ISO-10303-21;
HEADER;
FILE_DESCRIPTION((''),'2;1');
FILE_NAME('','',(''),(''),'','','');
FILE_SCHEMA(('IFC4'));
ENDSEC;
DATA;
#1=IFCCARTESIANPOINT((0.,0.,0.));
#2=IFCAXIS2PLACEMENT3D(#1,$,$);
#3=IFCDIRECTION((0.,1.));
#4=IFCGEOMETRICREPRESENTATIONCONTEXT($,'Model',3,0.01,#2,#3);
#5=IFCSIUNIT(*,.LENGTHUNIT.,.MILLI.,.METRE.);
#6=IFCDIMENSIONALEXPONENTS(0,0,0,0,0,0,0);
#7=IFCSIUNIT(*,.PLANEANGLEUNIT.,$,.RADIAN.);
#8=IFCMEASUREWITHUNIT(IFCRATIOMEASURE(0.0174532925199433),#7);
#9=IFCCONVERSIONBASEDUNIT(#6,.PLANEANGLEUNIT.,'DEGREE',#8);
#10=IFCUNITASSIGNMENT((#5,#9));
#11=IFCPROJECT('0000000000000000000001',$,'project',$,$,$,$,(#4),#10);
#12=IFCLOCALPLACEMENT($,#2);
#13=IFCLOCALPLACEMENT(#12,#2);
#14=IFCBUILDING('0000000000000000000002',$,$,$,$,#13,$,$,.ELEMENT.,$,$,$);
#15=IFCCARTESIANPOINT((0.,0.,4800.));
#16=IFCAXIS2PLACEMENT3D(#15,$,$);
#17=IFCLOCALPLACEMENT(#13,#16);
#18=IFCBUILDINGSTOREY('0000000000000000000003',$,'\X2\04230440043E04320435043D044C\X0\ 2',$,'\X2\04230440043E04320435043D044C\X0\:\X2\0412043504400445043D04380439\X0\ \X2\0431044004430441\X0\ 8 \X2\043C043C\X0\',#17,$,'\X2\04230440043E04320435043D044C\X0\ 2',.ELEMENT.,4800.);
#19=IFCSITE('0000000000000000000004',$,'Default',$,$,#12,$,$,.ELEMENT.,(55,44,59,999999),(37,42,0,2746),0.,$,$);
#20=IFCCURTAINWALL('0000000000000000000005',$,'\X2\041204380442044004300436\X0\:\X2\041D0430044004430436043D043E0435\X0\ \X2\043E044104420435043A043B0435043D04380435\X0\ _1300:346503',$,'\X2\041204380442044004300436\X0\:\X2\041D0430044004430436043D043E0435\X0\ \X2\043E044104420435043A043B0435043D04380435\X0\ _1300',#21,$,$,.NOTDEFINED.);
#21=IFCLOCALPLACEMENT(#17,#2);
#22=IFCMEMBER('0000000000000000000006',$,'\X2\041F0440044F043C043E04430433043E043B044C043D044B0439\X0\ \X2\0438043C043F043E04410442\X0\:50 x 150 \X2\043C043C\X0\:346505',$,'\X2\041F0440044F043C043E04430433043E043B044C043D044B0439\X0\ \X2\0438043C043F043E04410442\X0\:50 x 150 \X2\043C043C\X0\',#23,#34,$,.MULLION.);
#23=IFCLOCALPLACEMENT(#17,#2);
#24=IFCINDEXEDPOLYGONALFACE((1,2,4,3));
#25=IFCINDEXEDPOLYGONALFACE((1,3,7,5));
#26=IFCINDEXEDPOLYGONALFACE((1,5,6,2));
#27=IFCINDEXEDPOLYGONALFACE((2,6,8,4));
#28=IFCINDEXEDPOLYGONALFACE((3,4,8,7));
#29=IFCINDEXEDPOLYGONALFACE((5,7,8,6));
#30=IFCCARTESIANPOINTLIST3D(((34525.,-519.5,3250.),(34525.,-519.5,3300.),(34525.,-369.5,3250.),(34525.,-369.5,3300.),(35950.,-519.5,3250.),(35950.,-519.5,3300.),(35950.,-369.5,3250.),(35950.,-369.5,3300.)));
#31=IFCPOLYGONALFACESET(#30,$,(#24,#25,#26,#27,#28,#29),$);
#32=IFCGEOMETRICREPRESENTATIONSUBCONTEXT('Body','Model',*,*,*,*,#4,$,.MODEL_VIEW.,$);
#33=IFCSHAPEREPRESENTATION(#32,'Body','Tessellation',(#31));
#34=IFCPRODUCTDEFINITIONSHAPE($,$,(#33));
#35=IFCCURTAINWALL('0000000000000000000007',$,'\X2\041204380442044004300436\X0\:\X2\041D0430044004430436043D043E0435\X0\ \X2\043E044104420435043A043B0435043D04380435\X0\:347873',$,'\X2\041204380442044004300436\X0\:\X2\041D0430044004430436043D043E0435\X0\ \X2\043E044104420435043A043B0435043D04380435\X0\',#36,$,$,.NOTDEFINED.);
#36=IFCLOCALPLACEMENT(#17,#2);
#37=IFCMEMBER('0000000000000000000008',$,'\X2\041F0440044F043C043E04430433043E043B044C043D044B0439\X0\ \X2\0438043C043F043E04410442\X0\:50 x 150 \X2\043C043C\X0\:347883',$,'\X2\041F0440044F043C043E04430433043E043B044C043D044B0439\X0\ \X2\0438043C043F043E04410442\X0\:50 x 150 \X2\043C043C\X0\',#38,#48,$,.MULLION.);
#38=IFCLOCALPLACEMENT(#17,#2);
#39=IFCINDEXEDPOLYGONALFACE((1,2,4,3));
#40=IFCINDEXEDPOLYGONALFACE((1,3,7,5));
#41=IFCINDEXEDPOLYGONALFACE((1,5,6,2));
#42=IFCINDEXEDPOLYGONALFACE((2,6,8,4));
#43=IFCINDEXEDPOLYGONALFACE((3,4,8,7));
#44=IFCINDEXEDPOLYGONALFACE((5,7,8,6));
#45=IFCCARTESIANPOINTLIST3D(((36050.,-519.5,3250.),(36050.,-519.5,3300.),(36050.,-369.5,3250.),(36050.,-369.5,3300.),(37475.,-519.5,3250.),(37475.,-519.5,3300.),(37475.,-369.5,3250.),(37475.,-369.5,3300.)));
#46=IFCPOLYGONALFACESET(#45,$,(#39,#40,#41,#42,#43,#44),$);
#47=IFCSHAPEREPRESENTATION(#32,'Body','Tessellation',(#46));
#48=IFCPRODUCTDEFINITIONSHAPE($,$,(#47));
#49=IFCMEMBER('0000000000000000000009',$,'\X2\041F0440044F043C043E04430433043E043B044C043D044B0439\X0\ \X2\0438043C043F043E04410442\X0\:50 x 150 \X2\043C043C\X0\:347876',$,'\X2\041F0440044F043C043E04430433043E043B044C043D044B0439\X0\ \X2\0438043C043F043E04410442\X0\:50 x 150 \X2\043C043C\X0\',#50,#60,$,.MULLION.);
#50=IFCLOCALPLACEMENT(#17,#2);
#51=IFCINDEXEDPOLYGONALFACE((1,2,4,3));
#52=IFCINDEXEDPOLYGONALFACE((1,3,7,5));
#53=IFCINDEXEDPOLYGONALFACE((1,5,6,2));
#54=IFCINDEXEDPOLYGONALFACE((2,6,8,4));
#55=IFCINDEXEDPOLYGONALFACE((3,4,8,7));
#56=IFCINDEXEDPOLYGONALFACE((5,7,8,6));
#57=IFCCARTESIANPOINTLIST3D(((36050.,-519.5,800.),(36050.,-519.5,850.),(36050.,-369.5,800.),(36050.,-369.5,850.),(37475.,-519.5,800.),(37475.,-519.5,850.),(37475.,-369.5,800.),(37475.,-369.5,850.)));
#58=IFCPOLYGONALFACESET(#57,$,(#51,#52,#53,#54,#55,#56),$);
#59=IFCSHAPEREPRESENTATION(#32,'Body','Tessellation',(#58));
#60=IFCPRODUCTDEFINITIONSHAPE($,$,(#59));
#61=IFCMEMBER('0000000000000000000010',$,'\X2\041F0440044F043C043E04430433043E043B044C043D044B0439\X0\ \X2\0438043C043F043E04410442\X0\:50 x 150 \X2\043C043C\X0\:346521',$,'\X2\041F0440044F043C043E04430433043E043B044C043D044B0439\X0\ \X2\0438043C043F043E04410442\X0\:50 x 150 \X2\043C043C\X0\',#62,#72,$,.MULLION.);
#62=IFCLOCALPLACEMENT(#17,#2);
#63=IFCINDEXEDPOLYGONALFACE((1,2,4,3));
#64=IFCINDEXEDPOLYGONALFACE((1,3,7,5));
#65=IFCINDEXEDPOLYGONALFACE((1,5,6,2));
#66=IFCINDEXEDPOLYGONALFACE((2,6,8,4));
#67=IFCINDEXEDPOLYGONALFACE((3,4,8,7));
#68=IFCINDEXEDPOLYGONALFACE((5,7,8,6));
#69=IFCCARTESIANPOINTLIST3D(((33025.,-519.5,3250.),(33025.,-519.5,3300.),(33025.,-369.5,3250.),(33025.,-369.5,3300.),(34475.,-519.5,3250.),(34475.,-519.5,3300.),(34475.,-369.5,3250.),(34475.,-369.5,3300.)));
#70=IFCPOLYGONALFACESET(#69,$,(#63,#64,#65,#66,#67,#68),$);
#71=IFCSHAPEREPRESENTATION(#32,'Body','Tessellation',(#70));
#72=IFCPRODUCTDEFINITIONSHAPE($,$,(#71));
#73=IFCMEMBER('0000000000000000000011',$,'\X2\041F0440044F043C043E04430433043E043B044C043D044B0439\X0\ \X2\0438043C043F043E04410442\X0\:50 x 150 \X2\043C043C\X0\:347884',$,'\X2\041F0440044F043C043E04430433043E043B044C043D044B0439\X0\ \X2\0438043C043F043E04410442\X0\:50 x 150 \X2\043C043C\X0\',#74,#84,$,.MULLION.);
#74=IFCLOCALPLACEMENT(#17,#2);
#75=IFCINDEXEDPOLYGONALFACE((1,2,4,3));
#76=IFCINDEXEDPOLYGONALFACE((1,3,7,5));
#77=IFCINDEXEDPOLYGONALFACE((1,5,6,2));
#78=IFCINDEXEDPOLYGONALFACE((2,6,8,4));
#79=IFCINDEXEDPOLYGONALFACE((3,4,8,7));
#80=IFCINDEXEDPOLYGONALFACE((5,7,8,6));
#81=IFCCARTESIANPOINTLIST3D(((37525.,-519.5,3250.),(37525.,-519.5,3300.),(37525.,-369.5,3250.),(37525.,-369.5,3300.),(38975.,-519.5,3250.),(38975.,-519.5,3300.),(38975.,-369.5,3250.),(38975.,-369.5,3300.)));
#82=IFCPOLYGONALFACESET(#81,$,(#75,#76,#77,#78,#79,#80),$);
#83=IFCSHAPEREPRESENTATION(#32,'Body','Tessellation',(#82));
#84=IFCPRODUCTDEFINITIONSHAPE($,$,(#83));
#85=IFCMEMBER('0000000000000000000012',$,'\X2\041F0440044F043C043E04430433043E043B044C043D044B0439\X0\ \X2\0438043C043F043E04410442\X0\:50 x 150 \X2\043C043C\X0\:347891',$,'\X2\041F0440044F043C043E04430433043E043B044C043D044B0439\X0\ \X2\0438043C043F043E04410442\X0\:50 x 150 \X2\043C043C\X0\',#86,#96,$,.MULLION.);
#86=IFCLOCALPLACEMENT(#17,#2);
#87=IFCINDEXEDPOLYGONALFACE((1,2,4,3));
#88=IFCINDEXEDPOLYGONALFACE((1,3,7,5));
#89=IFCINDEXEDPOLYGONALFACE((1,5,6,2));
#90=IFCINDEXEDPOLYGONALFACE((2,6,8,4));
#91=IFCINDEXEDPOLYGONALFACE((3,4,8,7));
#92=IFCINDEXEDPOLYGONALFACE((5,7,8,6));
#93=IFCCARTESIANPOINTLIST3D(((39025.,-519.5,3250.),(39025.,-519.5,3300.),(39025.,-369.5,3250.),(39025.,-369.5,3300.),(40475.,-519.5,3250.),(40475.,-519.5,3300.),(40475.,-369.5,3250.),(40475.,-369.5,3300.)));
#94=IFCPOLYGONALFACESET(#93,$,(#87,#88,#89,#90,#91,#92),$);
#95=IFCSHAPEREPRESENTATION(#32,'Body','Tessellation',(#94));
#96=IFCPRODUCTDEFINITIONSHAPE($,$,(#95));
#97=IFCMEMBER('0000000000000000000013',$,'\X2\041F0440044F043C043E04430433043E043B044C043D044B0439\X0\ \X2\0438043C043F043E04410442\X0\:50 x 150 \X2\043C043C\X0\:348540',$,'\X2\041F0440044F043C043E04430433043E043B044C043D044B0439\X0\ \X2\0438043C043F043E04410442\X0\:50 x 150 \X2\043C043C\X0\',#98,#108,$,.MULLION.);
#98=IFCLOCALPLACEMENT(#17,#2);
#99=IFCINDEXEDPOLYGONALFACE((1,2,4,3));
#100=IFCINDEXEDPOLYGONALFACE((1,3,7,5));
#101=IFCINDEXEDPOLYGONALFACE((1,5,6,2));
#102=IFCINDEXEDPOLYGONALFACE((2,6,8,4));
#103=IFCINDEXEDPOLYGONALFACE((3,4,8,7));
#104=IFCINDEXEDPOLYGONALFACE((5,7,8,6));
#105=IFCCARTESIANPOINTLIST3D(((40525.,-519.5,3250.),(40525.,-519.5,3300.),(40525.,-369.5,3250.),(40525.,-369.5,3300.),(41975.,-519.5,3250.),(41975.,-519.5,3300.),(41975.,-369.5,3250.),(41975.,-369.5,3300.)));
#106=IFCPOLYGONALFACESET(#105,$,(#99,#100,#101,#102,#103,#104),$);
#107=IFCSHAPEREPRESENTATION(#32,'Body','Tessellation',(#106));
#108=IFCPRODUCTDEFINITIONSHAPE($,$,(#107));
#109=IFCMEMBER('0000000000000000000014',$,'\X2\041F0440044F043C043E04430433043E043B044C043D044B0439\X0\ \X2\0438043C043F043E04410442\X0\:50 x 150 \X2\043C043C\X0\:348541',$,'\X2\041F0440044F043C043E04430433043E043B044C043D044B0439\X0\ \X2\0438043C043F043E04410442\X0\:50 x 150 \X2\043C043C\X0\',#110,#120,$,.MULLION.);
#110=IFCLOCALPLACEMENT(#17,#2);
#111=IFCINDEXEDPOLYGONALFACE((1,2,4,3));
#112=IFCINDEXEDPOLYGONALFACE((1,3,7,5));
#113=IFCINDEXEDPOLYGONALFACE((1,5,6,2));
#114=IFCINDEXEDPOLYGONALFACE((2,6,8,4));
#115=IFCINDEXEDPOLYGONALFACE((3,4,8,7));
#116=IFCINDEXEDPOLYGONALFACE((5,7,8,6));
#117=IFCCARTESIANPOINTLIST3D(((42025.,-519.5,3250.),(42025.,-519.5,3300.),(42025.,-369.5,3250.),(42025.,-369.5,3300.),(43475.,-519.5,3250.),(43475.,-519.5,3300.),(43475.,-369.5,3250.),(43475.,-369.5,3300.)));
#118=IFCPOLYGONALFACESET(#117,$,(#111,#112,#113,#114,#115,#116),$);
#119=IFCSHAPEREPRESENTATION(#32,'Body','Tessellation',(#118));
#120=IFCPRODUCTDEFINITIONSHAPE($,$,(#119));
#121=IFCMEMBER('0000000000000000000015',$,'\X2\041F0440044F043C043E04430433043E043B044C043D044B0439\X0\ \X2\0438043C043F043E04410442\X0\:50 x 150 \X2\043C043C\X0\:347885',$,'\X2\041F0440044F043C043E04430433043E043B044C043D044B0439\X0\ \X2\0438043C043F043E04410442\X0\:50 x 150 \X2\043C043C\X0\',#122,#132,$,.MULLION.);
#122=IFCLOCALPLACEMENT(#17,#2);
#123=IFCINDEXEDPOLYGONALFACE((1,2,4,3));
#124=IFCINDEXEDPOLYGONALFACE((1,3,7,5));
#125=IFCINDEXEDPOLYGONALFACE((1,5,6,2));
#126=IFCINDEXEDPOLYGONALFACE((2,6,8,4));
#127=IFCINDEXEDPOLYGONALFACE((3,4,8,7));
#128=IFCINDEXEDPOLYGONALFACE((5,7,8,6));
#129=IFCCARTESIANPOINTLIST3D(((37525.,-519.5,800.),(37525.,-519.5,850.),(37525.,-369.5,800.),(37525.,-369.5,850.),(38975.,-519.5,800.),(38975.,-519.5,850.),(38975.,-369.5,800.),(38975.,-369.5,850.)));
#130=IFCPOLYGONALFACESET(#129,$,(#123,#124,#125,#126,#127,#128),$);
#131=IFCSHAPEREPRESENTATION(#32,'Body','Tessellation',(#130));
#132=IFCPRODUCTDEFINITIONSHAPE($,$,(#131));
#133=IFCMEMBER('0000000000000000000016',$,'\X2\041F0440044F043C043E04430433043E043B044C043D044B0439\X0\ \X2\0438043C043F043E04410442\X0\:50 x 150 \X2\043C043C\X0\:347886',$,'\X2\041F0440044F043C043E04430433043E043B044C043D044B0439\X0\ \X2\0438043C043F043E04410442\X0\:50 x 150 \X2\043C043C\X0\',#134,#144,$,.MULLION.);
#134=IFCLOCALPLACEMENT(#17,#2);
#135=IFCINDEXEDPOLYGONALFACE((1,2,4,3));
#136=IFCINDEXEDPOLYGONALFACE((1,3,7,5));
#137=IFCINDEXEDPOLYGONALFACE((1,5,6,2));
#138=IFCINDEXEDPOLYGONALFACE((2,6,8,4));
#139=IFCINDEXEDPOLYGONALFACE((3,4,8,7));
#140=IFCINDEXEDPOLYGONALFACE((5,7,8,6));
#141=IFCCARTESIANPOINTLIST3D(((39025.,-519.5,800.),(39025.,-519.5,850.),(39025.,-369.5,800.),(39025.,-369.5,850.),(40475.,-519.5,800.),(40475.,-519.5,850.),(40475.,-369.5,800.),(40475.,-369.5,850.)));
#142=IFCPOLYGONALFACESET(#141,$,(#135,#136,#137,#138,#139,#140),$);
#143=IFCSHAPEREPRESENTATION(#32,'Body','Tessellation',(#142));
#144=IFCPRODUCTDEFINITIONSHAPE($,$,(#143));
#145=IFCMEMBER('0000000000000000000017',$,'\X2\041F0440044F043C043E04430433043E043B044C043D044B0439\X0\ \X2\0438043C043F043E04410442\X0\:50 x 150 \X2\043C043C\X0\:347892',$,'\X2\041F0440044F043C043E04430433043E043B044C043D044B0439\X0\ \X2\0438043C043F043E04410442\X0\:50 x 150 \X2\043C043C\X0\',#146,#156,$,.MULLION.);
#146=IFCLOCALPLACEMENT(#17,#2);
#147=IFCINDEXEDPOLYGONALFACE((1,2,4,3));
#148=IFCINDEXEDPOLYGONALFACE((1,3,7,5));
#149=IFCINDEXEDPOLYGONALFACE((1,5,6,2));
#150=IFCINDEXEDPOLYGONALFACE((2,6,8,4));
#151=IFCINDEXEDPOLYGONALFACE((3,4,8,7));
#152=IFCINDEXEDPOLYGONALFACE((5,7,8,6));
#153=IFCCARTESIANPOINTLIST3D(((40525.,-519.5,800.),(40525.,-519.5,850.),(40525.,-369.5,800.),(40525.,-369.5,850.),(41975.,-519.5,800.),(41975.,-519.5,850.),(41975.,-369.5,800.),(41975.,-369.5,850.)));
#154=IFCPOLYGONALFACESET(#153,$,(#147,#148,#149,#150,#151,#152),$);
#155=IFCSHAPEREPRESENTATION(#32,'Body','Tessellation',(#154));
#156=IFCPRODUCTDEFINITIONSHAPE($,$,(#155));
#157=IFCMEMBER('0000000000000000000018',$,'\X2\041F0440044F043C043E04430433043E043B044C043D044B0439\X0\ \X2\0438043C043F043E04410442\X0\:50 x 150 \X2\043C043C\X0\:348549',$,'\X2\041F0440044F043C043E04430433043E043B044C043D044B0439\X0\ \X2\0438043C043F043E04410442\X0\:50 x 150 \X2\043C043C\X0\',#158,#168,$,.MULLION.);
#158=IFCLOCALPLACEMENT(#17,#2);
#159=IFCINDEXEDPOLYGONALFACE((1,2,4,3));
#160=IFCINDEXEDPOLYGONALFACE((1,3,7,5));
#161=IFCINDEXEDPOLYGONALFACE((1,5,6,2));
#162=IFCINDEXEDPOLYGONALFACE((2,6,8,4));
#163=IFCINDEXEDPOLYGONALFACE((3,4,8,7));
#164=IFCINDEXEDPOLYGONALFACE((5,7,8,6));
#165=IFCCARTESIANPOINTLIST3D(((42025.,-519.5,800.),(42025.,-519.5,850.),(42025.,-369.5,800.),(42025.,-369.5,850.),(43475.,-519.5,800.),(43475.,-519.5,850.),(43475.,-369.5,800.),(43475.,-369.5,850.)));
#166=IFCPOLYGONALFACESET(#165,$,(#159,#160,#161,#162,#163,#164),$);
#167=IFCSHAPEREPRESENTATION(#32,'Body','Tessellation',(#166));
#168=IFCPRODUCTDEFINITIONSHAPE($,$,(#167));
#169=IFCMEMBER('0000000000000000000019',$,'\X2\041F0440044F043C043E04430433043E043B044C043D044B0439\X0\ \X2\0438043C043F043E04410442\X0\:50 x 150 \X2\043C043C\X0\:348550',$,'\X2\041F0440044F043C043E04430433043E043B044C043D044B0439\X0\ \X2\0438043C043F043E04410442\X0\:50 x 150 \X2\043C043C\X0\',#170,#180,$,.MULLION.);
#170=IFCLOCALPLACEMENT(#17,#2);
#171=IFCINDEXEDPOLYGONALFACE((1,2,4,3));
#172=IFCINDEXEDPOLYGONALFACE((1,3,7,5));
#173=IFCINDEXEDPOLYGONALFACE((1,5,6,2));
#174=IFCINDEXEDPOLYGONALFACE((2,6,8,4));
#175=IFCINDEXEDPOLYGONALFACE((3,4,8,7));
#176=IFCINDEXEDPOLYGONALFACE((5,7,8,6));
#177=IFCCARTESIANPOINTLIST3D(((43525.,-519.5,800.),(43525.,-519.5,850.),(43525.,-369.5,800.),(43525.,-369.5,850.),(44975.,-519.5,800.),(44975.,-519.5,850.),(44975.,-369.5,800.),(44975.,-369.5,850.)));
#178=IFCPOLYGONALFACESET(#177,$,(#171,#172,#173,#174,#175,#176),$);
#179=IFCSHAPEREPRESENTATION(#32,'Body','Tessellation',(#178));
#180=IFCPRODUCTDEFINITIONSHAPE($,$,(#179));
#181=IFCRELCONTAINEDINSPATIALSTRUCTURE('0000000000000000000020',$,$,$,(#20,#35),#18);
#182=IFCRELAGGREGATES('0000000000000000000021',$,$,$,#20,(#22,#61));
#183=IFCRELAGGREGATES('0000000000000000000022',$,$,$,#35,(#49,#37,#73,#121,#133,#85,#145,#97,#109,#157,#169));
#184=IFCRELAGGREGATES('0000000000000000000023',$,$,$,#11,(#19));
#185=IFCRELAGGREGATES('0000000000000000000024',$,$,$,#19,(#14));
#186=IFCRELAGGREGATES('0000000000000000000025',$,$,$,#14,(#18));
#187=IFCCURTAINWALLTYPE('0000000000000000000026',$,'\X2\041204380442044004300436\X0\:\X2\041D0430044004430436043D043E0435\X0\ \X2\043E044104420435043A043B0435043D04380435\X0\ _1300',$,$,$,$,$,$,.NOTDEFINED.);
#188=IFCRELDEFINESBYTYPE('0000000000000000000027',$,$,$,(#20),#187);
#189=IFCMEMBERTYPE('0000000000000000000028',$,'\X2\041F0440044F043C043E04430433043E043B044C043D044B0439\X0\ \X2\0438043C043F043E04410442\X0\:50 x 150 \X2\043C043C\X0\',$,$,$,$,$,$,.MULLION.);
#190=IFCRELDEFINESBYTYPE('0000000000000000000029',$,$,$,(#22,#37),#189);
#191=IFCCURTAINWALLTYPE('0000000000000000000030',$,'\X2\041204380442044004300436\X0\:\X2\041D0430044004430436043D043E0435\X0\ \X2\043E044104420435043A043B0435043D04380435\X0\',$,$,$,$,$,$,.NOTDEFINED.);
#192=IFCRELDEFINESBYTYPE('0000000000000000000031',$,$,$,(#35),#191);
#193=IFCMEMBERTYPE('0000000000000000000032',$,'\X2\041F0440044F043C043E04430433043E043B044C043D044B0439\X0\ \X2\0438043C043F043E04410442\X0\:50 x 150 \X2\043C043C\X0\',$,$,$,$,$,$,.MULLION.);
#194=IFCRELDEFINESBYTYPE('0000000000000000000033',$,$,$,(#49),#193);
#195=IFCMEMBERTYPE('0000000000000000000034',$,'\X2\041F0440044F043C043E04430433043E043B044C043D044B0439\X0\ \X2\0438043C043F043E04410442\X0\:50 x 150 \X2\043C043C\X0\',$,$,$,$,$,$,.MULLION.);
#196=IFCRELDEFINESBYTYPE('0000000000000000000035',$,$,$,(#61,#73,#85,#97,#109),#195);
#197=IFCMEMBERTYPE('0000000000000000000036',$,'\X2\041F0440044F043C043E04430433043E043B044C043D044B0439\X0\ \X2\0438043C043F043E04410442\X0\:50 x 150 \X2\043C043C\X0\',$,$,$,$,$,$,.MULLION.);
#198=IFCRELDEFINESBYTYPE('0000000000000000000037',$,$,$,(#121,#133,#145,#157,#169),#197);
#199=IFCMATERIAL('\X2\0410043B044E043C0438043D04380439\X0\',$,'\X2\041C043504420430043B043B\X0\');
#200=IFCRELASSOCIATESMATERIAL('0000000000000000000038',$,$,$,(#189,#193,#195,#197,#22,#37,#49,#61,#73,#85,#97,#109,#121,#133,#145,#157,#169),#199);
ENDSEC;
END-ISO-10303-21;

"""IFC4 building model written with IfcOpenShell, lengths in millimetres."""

from ifc_helpers import new_model, entity, si_unit, converted_unit, direction, frame, origin, origin_2d_with_axis, place, context, subcontext, project, spatial, rectangle, extrude, source, transform, mapped, material, material_profile, profile_set, profile_usage, type_object, type_shapes, element, aggregate, save


model = new_model("IFC4")

# Units and contexts
model_context = context("Model", 3, precision=0.01, world=origin(), true_north=direction((0.0, 1.0)))
body_context = subcontext(model_context, "Body", "Model", "MODEL_VIEW")
ifc_project = project(units=[si_unit("LENGTHUNIT", "METRE", prefix="MILLI"), converted_unit("PLANEANGLEUNIT", "DEGREE", entity("IfcRatioMeasure", 0.0174532925199433), si_unit("PLANEANGLEUNIT", "RADIAN"), dimensions=[0, 0, 0, 0, 0, 0, 0])], contexts=[model_context])

# Site, building, storey
site_placement = place(None, origin())
site = spatial("IfcSite", under=ifc_project, at=site_placement, Name="Default", CompositionType="ELEMENT", RefLatitude=(55, 44, 59, 999999), RefLongitude=(37, 42, 0, 2746), RefElevation=0.0)
building_placement = place(site_placement, origin())
building = spatial("IfcBuilding", under=site, at=building_placement, CompositionType="ELEMENT")
storey_placement = place(building_placement, frame((0.0, 0.0, 4800.0)))
storey = spatial("IfcBuildingStorey", under=building, at=storey_placement, Name="Уровень 2", ObjectType="Уровень:Верхний брус 8 мм", LongName="Уровень 2", CompositionType="ELEMENT", Elevation=4800.0)

# Curtain wall, member
curtain_wall_type_1 = type_object("IfcCurtainWallType", Name="Витраж:Наружное остекление _1300", PredefinedType="NOTDEFINED")
curtain_wall_1_placement = place(storey_placement, frame((0.0, 0.0, -4800.0)))
curtain_wall_1 = element("IfcCurtainWall", 1, at=curtain_wall_1_placement, inside=storey, type_object=curtain_wall_type_1, Name="Витраж:Наружное остекление _1300:346503", ObjectType="Витраж:Наружное остекление _1300", PredefinedType="NOTDEFINED")
ifc_material = material(Name="Алюминий", Category="Металл")
ifc_material_profile = material_profile(ifc_material, rectangle(XDim=150.0, YDim=50.0, at=origin_2d_with_axis()), Name="50 x 150 мм")
ifc_profile_set = profile_set([ifc_material_profile], Name="50 x 150 мм")
ifc_profile_usage_1 = profile_usage(ifc_profile_set)
member_type_1 = type_object("IfcMemberType", Name="Прямоугольный импост:50 x 150 мм", PredefinedType="MULLION", material=ifc_profile_set)
shared_shape_1 = source(origin(), body_context, "Body", "SweptSolid", [
    extrude(rectangle(XDim=150.0, YDim=50.0, at=origin_2d_with_axis()), frame((-25.0, 0.0, -1425.0), z_axis=(0.0, 0.0, 1.0), x_axis=(0.0, -1.0, 0.0)), (0.0, 0.0, 1.0), 1425.0),
])
type_shapes(member_type_1, [shared_shape_1])
member_1_placement = place(storey_placement, frame((35950.0, -444.5, 3300.0), z_axis=(1.0, 0.0, 0.0), x_axis=(0.0, 0.0, 1.0)))
member_1 = element("IfcMember", 2, at=member_1_placement, type_object=member_type_1, material=ifc_profile_usage_1, Name="Прямоугольный импост:50 x 150 мм:346505", ObjectType="Прямоугольный импост:50 x 150 мм", PredefinedType="MULLION", context=body_context, shape_type="MappedRepresentation", body=[
    mapped(shared_shape_1, transform((0.0, 0.0, 0.0), scale=1.0)),
])

# Curtain wall, members
curtain_wall_type_2 = type_object("IfcCurtainWallType", Name="Витраж:Наружное остекление", PredefinedType="NOTDEFINED")
curtain_wall_2_placement = place(storey_placement, frame((0.0, 0.0, -4800.0)))
curtain_wall_2 = element("IfcCurtainWall", 3, at=curtain_wall_2_placement, inside=storey, type_object=curtain_wall_type_2, Name="Витраж:Наружное остекление:347873", ObjectType="Витраж:Наружное остекление", PredefinedType="NOTDEFINED")
ifc_profile_usage_2 = profile_usage(ifc_profile_set)
member_2_placement = place(storey_placement, frame((37475.0, -444.5, 3300.0), z_axis=(1.0, 0.0, 0.0), x_axis=(0.0, 0.0, 1.0)))
member_2 = element("IfcMember", 4, at=member_2_placement, type_object=member_type_1, material=ifc_profile_usage_2, Name="Прямоугольный импост:50 x 150 мм:347883", ObjectType="Прямоугольный импост:50 x 150 мм", PredefinedType="MULLION", context=body_context, shape_type="MappedRepresentation", body=[
    mapped(shared_shape_1, transform((0.0, 0.0, 0.0), scale=1.0)),
])
ifc_profile_usage_3 = profile_usage(ifc_profile_set)
member_type_2 = type_object("IfcMemberType", Name="Прямоугольный импост:50 x 150 мм", PredefinedType="MULLION", material=ifc_profile_set)
shared_shape_2 = source(origin(), body_context, "Body", "SweptSolid", [
    extrude(rectangle(XDim=150.0, YDim=50.0, at=origin_2d_with_axis()), frame((-25.0, 0.0, -1425.0), z_axis=(0.0, 0.0, 1.0), x_axis=(0.0, -1.0, 0.0)), (0.0, 0.0, 1.0), 1425.0),
])
type_shapes(member_type_2, [shared_shape_2])
member_3_placement = place(storey_placement, frame((36050.0, -444.5, 800.0), z_axis=(-1.0, 0.0, 0.0), x_axis=(0.0, 0.0, -1.0)))
member_3 = element("IfcMember", 5, at=member_3_placement, type_object=member_type_2, material=ifc_profile_usage_3, Name="Прямоугольный импост:50 x 150 мм:347876", ObjectType="Прямоугольный импост:50 x 150 мм", PredefinedType="MULLION", context=body_context, shape_type="MappedRepresentation", body=[
    mapped(shared_shape_2, transform((0.0, 0.0, 0.0), scale=1.0)),
])

# Members
ifc_profile_usage_4 = profile_usage(ifc_profile_set)
member_type_3 = type_object("IfcMemberType", Name="Прямоугольный импост:50 x 150 мм", PredefinedType="MULLION", material=ifc_profile_set)
shared_shape_3 = source(origin(), body_context, "Body", "SweptSolid", [
    extrude(rectangle(XDim=150.0, YDim=50.0, at=origin_2d_with_axis()), frame((-25.0, 0.0, -1450.0), z_axis=(0.0, 0.0, 1.0), x_axis=(0.0, -1.0, 0.0)), (0.0, 0.0, 1.0), 1450.0),
])
type_shapes(member_type_3, [shared_shape_3])
member_4_placement = place(storey_placement, frame((34475.0, -444.5, 3300.0), z_axis=(1.0, 0.0, 0.0), x_axis=(0.0, 0.0, 1.0)))
member_4 = element("IfcMember", 6, at=member_4_placement, type_object=member_type_3, material=ifc_profile_usage_4, Name="Прямоугольный импост:50 x 150 мм:346521", ObjectType="Прямоугольный импост:50 x 150 мм", PredefinedType="MULLION", context=body_context, shape_type="MappedRepresentation", body=[
    mapped(shared_shape_3, transform((0.0, 0.0, 0.0), scale=1.0)),
])
ifc_profile_usage_5 = profile_usage(ifc_profile_set)
member_5_placement = place(storey_placement, frame((38975.0, -444.5, 3300.0), z_axis=(1.0, 0.0, 0.0), x_axis=(0.0, 0.0, 1.0)))
member_5 = element("IfcMember", 7, at=member_5_placement, type_object=member_type_3, material=ifc_profile_usage_5, Name="Прямоугольный импост:50 x 150 мм:347884", ObjectType="Прямоугольный импост:50 x 150 мм", PredefinedType="MULLION", context=body_context, shape_type="MappedRepresentation", body=[
    mapped(shared_shape_3, transform((0.0, 0.0, 0.0), scale=1.0)),
])
ifc_profile_usage_6 = profile_usage(ifc_profile_set)
member_6_placement = place(storey_placement, frame((40475.0, -444.5, 3300.0), z_axis=(1.0, 0.0, 0.0), x_axis=(0.0, 0.0, 1.0)))
member_6 = element("IfcMember", 8, at=member_6_placement, type_object=member_type_3, material=ifc_profile_usage_6, Name="Прямоугольный импост:50 x 150 мм:347891", ObjectType="Прямоугольный импост:50 x 150 мм", PredefinedType="MULLION", context=body_context, shape_type="MappedRepresentation", body=[
    mapped(shared_shape_3, transform((0.0, 0.0, 0.0), scale=1.0)),
])
ifc_profile_usage_7 = profile_usage(ifc_profile_set)
member_7_placement = place(storey_placement, frame((41975.0, -444.5, 3300.0), z_axis=(1.0, 0.0, 0.0), x_axis=(0.0, 0.0, 1.0)))
member_7 = element("IfcMember", 9, at=member_7_placement, type_object=member_type_3, material=ifc_profile_usage_7, Name="Прямоугольный импост:50 x 150 мм:348540", ObjectType="Прямоугольный импост:50 x 150 мм", PredefinedType="MULLION", context=body_context, shape_type="MappedRepresentation", body=[
    mapped(shared_shape_3, transform((0.0, 0.0, 0.0), scale=1.0)),
])
ifc_profile_usage_8 = profile_usage(ifc_profile_set)
member_8_placement = place(storey_placement, frame((43475.0, -444.5, 3300.0), z_axis=(1.0, 0.0, 0.0), x_axis=(0.0, 0.0, 1.0)))
member_8 = element("IfcMember", 10, at=member_8_placement, type_object=member_type_3, material=ifc_profile_usage_8, Name="Прямоугольный импост:50 x 150 мм:348541", ObjectType="Прямоугольный импост:50 x 150 мм", PredefinedType="MULLION", context=body_context, shape_type="MappedRepresentation", body=[
    mapped(shared_shape_3, transform((0.0, 0.0, 0.0), scale=1.0)),
])
ifc_profile_usage_9 = profile_usage(ifc_profile_set)
member_type_4 = type_object("IfcMemberType", Name="Прямоугольный импост:50 x 150 мм", PredefinedType="MULLION", material=ifc_profile_set)
shared_shape_4 = source(origin(), body_context, "Body", "SweptSolid", [
    extrude(rectangle(XDim=150.0, YDim=50.0, at=origin_2d_with_axis()), frame((-25.0, 0.0, -1450.0), z_axis=(0.0, 0.0, 1.0), x_axis=(0.0, -1.0, 0.0)), (0.0, 0.0, 1.0), 1450.0),
])
type_shapes(member_type_4, [shared_shape_4])
member_9_placement = place(storey_placement, frame((37525.0, -444.5, 800.0), z_axis=(-1.0, 0.0, 0.0), x_axis=(0.0, 0.0, -1.0)))
member_9 = element("IfcMember", 11, at=member_9_placement, type_object=member_type_4, material=ifc_profile_usage_9, Name="Прямоугольный импост:50 x 150 мм:347885", ObjectType="Прямоугольный импост:50 x 150 мм", PredefinedType="MULLION", context=body_context, shape_type="MappedRepresentation", body=[
    mapped(shared_shape_4, transform((0.0, 0.0, 0.0), scale=1.0)),
])
ifc_profile_usage_10 = profile_usage(ifc_profile_set)
member_10_placement = place(storey_placement, frame((39025.0, -444.5, 800.0), z_axis=(-1.0, 0.0, 0.0), x_axis=(0.0, 0.0, -1.0)))
member_10 = element("IfcMember", 12, at=member_10_placement, type_object=member_type_4, material=ifc_profile_usage_10, Name="Прямоугольный импост:50 x 150 мм:347886", ObjectType="Прямоугольный импост:50 x 150 мм", PredefinedType="MULLION", context=body_context, shape_type="MappedRepresentation", body=[
    mapped(shared_shape_4, transform((0.0, 0.0, 0.0), scale=1.0)),
])
ifc_profile_usage_11 = profile_usage(ifc_profile_set)
member_11_placement = place(storey_placement, frame((40525.0, -444.5, 800.0), z_axis=(-1.0, 0.0, 0.0), x_axis=(0.0, 0.0, -1.0)))
member_11 = element("IfcMember", 13, at=member_11_placement, type_object=member_type_4, material=ifc_profile_usage_11, Name="Прямоугольный импост:50 x 150 мм:347892", ObjectType="Прямоугольный импост:50 x 150 мм", PredefinedType="MULLION", context=body_context, shape_type="MappedRepresentation", body=[
    mapped(shared_shape_4, transform((0.0, 0.0, 0.0), scale=1.0)),
])
ifc_profile_usage_12 = profile_usage(ifc_profile_set)
member_12_placement = place(storey_placement, frame((42025.0, -444.5, 800.0), z_axis=(-1.0, 0.0, 0.0), x_axis=(0.0, 0.0, -1.0)))
member_12 = element("IfcMember", 14, at=member_12_placement, type_object=member_type_4, material=ifc_profile_usage_12, Name="Прямоугольный импост:50 x 150 мм:348549", ObjectType="Прямоугольный импост:50 x 150 мм", PredefinedType="MULLION", context=body_context, shape_type="MappedRepresentation", body=[
    mapped(shared_shape_4, transform((0.0, 0.0, 0.0), scale=1.0)),
])
ifc_profile_usage_13 = profile_usage(ifc_profile_set)
member_13_placement = place(storey_placement, frame((43525.0, -444.5, 800.0), z_axis=(-1.0, 0.0, 0.0), x_axis=(0.0, 0.0, -1.0)))
member_13 = element("IfcMember", 15, at=member_13_placement, type_object=member_type_4, material=ifc_profile_usage_13, Name="Прямоугольный импост:50 x 150 мм:348550", ObjectType="Прямоугольный импост:50 x 150 мм", PredefinedType="MULLION", context=body_context, shape_type="MappedRepresentation", body=[
    mapped(shared_shape_4, transform((0.0, 0.0, 0.0), scale=1.0)),
])
aggregate(curtain_wall_1, [member_1, member_4])
aggregate(curtain_wall_2, [member_3, member_2, member_5, member_9, member_10, member_6, member_11, member_7, member_8, member_12, member_13])

save(model, "model.ifc")
